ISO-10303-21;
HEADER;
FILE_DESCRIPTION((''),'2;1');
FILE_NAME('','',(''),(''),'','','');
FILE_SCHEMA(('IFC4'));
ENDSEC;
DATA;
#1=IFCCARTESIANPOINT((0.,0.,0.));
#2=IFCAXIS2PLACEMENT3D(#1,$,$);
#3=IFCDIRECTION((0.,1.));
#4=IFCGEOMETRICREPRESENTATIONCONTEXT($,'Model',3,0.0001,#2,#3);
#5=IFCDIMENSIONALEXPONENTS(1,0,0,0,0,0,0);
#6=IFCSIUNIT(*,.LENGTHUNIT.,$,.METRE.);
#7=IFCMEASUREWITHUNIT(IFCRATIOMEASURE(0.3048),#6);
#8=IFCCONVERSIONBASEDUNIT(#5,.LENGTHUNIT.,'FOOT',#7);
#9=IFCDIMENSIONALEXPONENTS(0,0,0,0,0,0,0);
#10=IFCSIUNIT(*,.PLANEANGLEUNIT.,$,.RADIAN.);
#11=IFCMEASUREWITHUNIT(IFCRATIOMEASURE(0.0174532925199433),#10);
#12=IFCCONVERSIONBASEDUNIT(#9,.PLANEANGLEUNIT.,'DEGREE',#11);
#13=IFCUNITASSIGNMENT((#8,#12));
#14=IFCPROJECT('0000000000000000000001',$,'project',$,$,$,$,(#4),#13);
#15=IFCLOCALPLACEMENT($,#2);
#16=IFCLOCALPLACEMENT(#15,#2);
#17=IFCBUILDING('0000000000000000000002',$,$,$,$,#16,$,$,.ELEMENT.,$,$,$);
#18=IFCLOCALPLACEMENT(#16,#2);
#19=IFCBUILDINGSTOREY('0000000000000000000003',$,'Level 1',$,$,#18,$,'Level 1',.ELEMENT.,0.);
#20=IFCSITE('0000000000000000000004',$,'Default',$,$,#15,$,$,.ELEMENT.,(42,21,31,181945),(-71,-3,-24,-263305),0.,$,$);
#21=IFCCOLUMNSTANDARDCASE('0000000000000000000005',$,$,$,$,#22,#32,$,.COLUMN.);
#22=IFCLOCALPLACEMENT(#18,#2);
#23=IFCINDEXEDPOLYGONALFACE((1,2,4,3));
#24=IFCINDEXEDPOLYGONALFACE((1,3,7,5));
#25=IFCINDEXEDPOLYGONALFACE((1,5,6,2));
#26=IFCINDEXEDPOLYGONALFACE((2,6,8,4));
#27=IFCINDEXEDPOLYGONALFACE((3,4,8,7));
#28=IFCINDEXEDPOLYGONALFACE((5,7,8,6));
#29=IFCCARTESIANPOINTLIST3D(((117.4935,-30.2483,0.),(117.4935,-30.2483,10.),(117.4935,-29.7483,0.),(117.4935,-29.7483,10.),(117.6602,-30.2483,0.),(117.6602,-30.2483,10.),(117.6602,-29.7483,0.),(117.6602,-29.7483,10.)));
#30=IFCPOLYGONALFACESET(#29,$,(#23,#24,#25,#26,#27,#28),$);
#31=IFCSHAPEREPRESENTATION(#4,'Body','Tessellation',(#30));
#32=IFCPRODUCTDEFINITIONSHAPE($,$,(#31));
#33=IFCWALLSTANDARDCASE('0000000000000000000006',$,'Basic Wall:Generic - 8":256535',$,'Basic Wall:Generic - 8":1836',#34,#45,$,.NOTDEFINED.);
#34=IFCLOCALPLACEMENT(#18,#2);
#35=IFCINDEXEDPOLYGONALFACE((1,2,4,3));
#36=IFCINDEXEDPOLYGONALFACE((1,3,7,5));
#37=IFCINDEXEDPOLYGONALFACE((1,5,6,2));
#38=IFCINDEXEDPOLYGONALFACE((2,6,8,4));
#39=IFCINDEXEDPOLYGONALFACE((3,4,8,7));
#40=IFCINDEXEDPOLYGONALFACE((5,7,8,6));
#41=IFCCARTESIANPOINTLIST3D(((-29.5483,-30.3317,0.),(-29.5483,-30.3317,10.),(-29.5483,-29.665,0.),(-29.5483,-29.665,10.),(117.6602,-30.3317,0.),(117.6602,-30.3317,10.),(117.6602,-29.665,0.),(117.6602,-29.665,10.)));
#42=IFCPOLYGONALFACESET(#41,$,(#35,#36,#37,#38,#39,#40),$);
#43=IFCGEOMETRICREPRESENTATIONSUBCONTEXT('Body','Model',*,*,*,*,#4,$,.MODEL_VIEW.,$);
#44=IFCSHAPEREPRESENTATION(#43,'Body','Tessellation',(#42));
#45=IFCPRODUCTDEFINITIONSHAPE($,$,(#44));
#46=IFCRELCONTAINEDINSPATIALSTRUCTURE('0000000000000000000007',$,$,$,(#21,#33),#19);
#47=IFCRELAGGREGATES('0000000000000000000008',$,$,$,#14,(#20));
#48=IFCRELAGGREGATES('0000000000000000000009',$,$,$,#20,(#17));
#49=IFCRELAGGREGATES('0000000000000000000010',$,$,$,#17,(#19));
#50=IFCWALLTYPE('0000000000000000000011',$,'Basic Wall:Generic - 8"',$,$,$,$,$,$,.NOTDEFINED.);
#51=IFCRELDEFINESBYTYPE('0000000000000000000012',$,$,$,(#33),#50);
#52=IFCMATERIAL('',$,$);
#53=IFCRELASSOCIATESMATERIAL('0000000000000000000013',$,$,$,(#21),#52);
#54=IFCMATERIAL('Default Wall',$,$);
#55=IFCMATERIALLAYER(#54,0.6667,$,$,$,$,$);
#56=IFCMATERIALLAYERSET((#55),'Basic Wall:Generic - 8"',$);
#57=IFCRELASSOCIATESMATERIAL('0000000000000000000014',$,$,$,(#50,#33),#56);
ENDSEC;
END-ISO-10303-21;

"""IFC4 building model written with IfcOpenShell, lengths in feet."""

from ifc_helpers import new_model, entity, si_unit, converted_unit, direction, frame, frame_2d, origin, place, context, subcontext, project, spatial, rectangle, extrude, material, layer, layer_set, layer_usage, type_object, element, save


model = new_model("IFC4")

# Units and contexts
model_context = context("Model", 3, precision=0.0001, world=origin(), true_north=direction((0.0, 1.0)))
body_context = subcontext(model_context, "Body", "Model", "MODEL_VIEW")
ifc_project = project(units=[converted_unit("LENGTHUNIT", "FOOT", entity("IfcRatioMeasure", 0.3048), si_unit("LENGTHUNIT", "METRE"), dimensions=[1, 0, 0, 0, 0, 0, 0]), converted_unit("PLANEANGLEUNIT", "DEGREE", entity("IfcRatioMeasure", 0.0174532925199433), si_unit("PLANEANGLEUNIT", "RADIAN"), dimensions=[0, 0, 0, 0, 0, 0, 0])], contexts=[model_context])

# Site, building, storey
site_placement = place(None, origin())
site = spatial("IfcSite", under=ifc_project, at=site_placement, Name="Default", CompositionType="ELEMENT", RefLatitude=(42, 21, 31, 181945), RefLongitude=(-71, -3, -24, -263305), RefElevation=0.0)
building_placement = place(site_placement, origin())
building = spatial("IfcBuilding", under=site, at=building_placement, CompositionType="ELEMENT")
storey_placement = place(building_placement, origin())
storey = spatial("IfcBuildingStorey", under=building, at=storey_placement, Name="Level 1", LongName="Level 1", CompositionType="ELEMENT", Elevation=0.0)

# Column
ifc_material_1 = material(Name="")
wall_placement = place(storey_placement, frame((117.6602, -29.9983, 0.0), z_axis=(0.0, 0.0, 1.0), x_axis=(-1.0, 0.0, 0.0)))
for number, where, z_axis, x_axis in (
    (1, (0.0833, 0.0, 0.0), (0.0, 0.0, 1.0), (1.0, 0.0, 0.0)),
):
    element("IfcColumnStandardCase", number, at=place(wall_placement, frame(where, z_axis=z_axis, x_axis=x_axis)), inside=storey, material=ifc_material_1, PredefinedType="COLUMN", context=model_context, shape_type="SweptSolid", body=[
        extrude(rectangle(XDim=0.1667, YDim=0.5), origin(), (0.0, 0.0, 1.0), 10.0),
    ])

# Wall
ifc_material_2 = material(Name="Default Wall")
ifc_layer = layer(ifc_material_2, 0.6667)
ifc_layer_set = layer_set([ifc_layer], Name="Basic Wall:Generic - 8\"")
ifc_layer_usage = layer_usage(ifc_layer_set, "AXIS2", "NEGATIVE", 0.3333)
wall_type = type_object("IfcWallType", Name="Basic Wall:Generic - 8\"", PredefinedType="NOTDEFINED", material=ifc_layer_set)
element("IfcWallStandardCase", 2, at=wall_placement, inside=storey, type_object=wall_type, material=ifc_layer_usage, Name="Basic Wall:Generic - 8\":256535", ObjectType="Basic Wall:Generic - 8\":1836", PredefinedType="NOTDEFINED", context=body_context, shape_type="SweptSolid", body=[
    extrude(rectangle(XDim=147.2085, YDim=0.6667, at=frame_2d((73.6043, 0.0), x_axis=(-1.0, 0.0))), origin(), (0.0, 0.0, 1.0), 10.0),
])

save(model, "model.ifc")
